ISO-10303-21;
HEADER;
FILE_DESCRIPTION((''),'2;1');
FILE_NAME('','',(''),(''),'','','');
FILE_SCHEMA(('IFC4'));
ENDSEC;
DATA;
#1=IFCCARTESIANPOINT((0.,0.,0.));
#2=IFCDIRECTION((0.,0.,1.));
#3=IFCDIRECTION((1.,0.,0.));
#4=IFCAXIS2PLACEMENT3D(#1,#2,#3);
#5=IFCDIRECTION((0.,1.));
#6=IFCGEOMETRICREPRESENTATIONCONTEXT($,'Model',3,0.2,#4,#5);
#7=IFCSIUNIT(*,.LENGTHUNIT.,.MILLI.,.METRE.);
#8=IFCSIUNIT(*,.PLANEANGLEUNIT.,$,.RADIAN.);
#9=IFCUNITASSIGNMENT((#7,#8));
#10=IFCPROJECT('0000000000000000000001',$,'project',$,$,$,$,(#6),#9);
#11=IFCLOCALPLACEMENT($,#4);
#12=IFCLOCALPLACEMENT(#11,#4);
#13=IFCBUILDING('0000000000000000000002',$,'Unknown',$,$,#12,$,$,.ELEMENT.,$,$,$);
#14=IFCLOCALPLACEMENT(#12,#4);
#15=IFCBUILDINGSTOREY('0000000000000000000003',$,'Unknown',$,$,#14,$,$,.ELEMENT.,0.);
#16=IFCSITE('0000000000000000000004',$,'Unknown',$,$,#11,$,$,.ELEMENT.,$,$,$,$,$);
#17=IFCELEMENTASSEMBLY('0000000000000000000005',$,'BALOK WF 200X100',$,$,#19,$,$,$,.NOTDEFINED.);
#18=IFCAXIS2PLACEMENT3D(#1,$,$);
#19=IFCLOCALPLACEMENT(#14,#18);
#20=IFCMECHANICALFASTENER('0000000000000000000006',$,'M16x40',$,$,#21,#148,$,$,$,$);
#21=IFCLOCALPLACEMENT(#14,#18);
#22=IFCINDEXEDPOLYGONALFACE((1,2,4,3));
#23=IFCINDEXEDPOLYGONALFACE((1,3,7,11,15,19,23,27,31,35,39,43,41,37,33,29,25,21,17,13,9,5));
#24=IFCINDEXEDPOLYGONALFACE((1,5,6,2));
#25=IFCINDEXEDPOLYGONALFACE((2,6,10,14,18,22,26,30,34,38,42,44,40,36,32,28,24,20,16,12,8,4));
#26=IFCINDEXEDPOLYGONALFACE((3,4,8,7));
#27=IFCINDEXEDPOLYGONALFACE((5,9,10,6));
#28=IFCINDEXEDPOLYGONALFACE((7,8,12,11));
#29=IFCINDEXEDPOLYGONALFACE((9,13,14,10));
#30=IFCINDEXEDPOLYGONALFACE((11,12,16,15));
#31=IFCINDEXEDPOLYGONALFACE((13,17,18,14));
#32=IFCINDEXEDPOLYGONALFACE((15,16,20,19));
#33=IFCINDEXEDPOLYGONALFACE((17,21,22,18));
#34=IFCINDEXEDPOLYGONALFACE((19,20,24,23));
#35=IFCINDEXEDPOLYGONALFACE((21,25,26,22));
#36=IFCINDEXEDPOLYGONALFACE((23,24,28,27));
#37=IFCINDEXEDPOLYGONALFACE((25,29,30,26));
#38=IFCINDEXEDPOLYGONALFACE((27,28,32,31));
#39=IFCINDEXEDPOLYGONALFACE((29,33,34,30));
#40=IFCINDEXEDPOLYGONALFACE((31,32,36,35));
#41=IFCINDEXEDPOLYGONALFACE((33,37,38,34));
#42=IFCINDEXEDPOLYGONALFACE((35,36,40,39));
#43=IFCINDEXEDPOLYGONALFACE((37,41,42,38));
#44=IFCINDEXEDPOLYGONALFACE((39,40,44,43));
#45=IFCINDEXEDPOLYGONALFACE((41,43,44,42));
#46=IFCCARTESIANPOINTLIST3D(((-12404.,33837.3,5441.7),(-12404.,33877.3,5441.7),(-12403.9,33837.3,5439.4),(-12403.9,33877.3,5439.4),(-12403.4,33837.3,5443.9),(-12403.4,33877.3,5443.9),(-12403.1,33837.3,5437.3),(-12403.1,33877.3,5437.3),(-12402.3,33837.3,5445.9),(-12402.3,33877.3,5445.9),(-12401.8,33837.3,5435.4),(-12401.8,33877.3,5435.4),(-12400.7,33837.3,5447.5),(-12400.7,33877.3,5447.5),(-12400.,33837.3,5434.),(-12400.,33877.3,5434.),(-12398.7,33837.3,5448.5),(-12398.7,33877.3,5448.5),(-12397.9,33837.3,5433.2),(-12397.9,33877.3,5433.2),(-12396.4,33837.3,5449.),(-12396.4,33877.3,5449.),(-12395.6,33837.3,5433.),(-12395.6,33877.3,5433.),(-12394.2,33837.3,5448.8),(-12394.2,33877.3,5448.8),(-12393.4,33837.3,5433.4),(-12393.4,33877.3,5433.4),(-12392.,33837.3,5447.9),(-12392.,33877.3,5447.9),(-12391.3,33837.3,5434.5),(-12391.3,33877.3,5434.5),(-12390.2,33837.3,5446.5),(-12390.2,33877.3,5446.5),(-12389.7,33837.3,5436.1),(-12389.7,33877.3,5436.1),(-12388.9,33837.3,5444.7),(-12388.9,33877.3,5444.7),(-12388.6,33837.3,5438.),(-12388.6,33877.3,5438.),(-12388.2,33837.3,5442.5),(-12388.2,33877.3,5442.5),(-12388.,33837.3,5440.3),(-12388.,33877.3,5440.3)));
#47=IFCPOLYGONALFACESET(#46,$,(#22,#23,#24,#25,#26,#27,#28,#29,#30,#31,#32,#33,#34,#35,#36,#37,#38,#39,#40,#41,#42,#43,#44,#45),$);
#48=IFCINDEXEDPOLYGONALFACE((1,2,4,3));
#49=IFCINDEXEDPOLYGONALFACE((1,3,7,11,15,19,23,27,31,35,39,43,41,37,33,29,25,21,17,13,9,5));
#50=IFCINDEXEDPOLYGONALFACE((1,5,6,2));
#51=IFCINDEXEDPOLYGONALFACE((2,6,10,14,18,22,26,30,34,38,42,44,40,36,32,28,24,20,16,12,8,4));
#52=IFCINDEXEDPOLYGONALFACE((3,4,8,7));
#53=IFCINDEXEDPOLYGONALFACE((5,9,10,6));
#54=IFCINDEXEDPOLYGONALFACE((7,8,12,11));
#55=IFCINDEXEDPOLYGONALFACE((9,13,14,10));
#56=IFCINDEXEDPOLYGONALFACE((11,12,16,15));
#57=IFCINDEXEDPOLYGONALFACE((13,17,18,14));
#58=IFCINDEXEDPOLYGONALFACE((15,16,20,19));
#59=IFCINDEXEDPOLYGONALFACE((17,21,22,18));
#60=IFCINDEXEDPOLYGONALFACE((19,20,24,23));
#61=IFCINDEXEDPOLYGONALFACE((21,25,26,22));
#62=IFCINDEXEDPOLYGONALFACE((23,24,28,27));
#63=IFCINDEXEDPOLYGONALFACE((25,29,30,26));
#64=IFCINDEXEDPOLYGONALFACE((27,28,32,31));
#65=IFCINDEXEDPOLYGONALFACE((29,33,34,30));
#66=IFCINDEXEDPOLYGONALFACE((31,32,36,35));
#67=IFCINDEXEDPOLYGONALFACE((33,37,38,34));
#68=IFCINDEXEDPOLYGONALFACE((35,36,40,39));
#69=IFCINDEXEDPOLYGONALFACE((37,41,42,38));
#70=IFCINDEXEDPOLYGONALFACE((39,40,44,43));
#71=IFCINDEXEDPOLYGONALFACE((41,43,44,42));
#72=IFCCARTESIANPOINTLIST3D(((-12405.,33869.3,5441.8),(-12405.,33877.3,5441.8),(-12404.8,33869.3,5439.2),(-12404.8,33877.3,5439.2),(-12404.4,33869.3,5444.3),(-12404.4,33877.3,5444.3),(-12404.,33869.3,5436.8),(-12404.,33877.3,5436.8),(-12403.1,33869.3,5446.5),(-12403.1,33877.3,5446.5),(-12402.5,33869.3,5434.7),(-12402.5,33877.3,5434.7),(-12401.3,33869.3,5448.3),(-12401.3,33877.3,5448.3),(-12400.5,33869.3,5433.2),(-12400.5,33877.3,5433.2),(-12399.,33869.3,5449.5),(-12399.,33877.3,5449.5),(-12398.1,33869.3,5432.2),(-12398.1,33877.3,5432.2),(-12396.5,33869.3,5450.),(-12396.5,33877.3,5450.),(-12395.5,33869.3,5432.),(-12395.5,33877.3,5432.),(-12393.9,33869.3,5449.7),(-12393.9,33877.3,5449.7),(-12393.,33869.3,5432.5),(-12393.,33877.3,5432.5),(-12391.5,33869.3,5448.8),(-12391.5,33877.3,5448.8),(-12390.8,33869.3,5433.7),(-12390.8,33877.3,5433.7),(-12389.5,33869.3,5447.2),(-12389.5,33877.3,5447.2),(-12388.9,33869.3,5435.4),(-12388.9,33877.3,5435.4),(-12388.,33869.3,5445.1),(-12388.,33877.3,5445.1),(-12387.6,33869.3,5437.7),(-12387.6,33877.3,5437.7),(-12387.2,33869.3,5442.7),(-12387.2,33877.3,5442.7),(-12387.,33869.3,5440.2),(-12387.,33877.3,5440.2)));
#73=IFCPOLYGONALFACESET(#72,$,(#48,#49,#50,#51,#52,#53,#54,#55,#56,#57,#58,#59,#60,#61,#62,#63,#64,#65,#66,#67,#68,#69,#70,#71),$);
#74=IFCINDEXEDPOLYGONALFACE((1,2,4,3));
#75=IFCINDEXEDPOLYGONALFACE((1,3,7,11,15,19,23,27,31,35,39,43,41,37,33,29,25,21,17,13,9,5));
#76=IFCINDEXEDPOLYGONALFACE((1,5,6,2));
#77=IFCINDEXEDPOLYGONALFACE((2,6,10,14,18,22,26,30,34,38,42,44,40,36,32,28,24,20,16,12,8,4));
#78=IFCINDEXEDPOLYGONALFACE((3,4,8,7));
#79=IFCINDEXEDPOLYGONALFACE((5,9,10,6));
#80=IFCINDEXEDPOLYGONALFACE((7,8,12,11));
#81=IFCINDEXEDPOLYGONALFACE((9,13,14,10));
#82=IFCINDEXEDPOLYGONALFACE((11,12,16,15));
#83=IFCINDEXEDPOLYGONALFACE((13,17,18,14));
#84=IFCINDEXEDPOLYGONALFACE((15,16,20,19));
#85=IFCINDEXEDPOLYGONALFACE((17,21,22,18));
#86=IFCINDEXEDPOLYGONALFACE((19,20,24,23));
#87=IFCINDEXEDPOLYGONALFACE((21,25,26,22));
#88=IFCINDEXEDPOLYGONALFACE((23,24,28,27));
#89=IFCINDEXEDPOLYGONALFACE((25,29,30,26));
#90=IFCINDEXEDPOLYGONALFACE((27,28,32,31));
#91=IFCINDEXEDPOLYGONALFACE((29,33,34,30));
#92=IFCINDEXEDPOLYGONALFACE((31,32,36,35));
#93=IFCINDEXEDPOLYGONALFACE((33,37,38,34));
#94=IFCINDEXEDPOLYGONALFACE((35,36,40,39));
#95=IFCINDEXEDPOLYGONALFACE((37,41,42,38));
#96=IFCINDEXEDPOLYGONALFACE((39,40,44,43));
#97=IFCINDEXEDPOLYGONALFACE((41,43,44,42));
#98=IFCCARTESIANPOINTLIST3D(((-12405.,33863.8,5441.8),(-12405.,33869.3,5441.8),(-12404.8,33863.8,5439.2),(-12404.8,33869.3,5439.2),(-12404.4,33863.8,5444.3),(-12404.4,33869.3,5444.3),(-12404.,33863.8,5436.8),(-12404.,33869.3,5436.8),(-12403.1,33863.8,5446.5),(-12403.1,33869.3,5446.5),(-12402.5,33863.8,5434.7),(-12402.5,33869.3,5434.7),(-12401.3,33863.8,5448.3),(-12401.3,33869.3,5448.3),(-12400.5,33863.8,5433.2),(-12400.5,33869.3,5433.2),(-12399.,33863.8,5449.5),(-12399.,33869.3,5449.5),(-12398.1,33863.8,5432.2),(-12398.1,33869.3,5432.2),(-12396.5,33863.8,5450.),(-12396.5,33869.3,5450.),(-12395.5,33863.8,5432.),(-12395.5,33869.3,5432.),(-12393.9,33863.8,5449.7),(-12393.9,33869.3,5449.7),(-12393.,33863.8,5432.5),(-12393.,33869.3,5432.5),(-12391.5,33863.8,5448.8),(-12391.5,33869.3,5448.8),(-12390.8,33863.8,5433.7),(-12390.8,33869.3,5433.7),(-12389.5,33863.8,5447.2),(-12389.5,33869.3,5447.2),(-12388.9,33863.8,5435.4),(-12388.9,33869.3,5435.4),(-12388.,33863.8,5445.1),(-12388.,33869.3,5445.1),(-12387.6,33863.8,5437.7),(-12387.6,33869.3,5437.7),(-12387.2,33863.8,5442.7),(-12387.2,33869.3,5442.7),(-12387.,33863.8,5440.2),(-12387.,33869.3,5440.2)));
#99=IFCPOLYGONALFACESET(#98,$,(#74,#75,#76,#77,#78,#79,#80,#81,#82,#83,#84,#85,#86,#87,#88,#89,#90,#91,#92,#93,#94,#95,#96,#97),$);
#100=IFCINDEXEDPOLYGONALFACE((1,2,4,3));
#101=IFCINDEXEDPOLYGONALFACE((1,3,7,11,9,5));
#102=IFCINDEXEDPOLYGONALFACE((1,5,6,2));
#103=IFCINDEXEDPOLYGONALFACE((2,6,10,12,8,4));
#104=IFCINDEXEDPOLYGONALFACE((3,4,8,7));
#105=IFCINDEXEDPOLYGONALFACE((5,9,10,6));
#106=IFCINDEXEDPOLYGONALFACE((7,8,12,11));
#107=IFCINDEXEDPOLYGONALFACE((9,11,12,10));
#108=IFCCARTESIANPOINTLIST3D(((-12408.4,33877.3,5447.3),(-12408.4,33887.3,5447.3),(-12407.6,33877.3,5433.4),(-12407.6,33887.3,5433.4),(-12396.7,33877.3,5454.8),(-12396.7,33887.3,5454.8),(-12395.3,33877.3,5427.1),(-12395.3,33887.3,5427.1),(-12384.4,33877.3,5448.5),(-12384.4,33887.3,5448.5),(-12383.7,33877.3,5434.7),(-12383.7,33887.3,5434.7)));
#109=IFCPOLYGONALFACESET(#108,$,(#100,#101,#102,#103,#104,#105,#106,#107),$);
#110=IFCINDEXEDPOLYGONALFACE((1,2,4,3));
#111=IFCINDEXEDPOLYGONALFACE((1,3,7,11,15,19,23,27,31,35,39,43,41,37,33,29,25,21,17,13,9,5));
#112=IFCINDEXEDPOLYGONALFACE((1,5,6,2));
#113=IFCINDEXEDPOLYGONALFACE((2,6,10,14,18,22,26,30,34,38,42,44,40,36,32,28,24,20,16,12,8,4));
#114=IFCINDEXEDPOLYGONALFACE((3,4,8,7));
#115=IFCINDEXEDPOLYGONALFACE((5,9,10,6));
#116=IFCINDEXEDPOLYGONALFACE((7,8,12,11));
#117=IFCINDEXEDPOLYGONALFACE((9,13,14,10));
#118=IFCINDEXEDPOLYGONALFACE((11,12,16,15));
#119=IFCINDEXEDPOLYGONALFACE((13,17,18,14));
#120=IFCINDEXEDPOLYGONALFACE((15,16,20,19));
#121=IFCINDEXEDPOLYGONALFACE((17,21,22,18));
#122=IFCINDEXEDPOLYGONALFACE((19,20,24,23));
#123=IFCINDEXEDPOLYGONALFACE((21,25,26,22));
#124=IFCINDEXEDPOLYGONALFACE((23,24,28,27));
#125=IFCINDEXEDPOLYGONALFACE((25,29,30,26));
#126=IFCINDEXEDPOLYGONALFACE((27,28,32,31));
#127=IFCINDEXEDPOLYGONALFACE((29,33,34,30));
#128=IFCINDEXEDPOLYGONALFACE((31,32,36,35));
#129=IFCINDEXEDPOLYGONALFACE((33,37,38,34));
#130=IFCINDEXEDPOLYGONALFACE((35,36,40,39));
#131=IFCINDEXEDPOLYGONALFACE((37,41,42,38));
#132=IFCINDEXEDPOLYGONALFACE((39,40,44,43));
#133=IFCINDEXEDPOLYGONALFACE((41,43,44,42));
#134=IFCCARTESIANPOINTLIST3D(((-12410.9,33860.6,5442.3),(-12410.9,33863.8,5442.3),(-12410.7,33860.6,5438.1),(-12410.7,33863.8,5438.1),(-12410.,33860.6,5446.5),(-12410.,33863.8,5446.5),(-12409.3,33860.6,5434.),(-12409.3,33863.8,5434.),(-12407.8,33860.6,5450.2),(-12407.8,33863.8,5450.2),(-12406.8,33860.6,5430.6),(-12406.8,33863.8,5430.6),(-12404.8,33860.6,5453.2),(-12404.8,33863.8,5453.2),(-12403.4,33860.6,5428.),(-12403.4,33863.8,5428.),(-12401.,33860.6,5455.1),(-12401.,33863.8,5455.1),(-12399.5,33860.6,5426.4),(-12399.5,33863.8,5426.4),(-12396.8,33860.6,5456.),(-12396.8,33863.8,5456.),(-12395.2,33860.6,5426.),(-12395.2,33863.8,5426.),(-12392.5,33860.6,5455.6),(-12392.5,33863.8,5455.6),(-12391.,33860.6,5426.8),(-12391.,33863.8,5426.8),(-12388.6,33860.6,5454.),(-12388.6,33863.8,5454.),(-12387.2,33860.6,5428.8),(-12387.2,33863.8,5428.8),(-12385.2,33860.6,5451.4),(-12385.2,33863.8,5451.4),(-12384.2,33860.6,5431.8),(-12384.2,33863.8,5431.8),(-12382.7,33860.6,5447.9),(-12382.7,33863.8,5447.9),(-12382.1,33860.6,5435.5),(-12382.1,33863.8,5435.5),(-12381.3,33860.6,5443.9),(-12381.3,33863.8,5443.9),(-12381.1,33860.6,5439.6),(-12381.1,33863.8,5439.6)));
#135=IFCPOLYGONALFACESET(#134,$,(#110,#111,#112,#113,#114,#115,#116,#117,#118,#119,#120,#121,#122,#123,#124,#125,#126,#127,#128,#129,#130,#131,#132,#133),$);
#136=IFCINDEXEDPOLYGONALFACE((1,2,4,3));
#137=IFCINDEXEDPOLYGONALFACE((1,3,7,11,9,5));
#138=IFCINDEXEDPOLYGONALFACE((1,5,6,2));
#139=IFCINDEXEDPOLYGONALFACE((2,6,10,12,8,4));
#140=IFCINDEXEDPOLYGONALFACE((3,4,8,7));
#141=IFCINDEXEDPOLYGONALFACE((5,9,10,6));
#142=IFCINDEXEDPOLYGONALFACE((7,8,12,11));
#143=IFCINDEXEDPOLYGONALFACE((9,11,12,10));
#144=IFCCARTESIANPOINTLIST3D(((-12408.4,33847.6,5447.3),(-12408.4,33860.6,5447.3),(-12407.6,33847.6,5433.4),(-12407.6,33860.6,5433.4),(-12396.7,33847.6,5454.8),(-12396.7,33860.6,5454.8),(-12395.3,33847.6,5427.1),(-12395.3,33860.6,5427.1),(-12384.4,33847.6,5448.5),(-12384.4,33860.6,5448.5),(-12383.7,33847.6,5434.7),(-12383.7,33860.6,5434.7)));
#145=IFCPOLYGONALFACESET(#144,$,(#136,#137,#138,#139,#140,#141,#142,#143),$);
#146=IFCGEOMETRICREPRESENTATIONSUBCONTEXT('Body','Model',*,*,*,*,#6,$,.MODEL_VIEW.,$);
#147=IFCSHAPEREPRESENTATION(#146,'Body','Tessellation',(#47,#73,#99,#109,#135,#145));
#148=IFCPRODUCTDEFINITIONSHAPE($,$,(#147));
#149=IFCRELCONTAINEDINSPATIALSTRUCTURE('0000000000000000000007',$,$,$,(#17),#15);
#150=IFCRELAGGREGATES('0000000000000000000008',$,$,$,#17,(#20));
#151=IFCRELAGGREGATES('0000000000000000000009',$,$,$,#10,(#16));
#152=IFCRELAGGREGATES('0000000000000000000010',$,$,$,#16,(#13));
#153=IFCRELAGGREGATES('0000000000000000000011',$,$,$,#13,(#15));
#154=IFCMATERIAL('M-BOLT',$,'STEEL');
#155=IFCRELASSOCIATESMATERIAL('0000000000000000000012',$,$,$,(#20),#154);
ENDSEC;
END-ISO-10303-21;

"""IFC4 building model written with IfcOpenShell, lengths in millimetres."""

from ifc_helpers import new_model, si_unit, direction, frame, origin_with_axes, place, context, subcontext, project, spatial, line, arc, indexed_curve, outline, extrude, source, transform, mapped, material, element, aggregate, save


model = new_model("IFC4")

# Units and contexts
model_context = context("Model", 3, precision=0.2, world=origin_with_axes(), true_north=direction((0.0, 1.0)))
body_context = subcontext(model_context, "Body", "Model", "MODEL_VIEW")
ifc_project = project(units=[si_unit("LENGTHUNIT", "METRE", prefix="MILLI"), si_unit("PLANEANGLEUNIT", "RADIAN")], contexts=[model_context])

# Site, building, storey
site_placement = place(None, origin_with_axes())
site = spatial("IfcSite", under=ifc_project, at=site_placement, Name="Unknown", CompositionType="ELEMENT")
building_placement = place(site_placement, origin_with_axes())
building = spatial("IfcBuilding", under=site, at=building_placement, Name="Unknown", CompositionType="ELEMENT")
storey_placement = place(building_placement, origin_with_axes())
storey = spatial("IfcBuildingStorey", under=building, at=storey_placement, Name="Unknown", CompositionType="ELEMENT", Elevation=0.0)

# Element assembly, mechanical fastener
assembly_1_placement = place(storey_placement, frame((-7044.1, 33866.5, 5721.5), z_axis=(0.0, 1.0, 0.0), x_axis=(-0.99863, 0.0, -0.052336)))
assembly_1 = element("IfcElementAssembly", 1, at=assembly_1_placement, inside=storey, Name="BALOK WF 200X100", PredefinedType="NOTDEFINED")
ifc_material_1 = material(Name="M-BOLT", Category="STEEL")
shared_shape_1 = source(origin_with_axes(), body_context, "Body", "SweptSolid", [
    extrude(outline(indexed_curve([(8.0, 0.0), (0.0, 8.0), (-8.0, 0.0), (0.0, -8.0)], segments=[arc(1, 2, 3), arc(3, 4, 1)])), frame((0.0, 0.0, 0.0), z_axis=(0.0, 0.0, -1.0), x_axis=(0.0, 1.0, 0.0)), (0.0, 0.0, 1.0), 40.0),
    extrude(outline(indexed_curve([(9.0, 0.0), (0.0, 9.0), (-9.0, 0.0), (0.0, -9.0)], segments=[arc(1, 2, 3), arc(3, 4, 1)])), frame((0.0, 0.0, 0.0), z_axis=(0.0, 0.0, -1.0), x_axis=(0.0, 1.0, 0.0)), (0.0, 0.0, 1.0), 8.0),
    extrude(outline(indexed_curve([(9.0, 0.0), (0.0, 9.0), (-9.0, 0.0), (0.0, -9.0)], segments=[arc(1, 2, 3), arc(3, 4, 1)])), frame((0.0, 0.0, -8.0), z_axis=(0.0, 0.0, -1.0), x_axis=(0.0, 1.0, 0.0)), (0.0, 0.0, 1.0), 5.5),
    extrude(outline(indexed_curve([(13.9, 0.0), (6.9, 12.0), (-6.9, 12.0), (-13.9, 0.0), (-6.9, -12.0), (6.9, -12.0)], segments=[line(1, 2, 3, 4, 5, 6, 1)])), frame((0.0, 0.0, 10.0), z_axis=(0.0, 0.0, -1.0), x_axis=(0.0, 1.0, 0.0)), (0.0, 0.0, 1.0), 10.0),
    extrude(outline(indexed_curve([(15.0, 0.0), (0.0, 15.0), (-15.0, 0.0), (0.0, -15.0)], segments=[arc(1, 2, 3), arc(3, 4, 1)])), frame((0.0, 0.0, -13.5), z_axis=(0.0, 0.0, -1.0), x_axis=(0.0, 1.0, 0.0)), (0.0, 0.0, 1.0), 3.2),
    extrude(outline(indexed_curve([(13.9, 0.0), (6.9, 12.0), (-6.9, 12.0), (-13.9, 0.0), (-6.9, -12.0), (6.9, -12.0)], segments=[line(1, 2, 3, 4, 5, 6, 1)])), frame((0.0, 0.0, -16.7), z_axis=(0.0, 0.0, -1.0), x_axis=(0.0, 1.0, 0.0)), (0.0, 0.0, 1.0), 13.0),
])
mechanical_fastener_1_placement = place(assembly_1_placement, frame((5359.2, 0.0, 10.7), z_axis=(-0.000004, 0.0, 1.0), x_axis=(-1.0, 0.0, -0.000004)))
mechanical_fastener_1 = element("IfcMechanicalFastener", 2, at=mechanical_fastener_1_placement, material=ifc_material_1, Name="M16x40", context=body_context, shape_type="MappedRepresentation", body=[
    mapped(shared_shape_1, transform((0.0, 0.0, 0.0))),
])
aggregate(assembly_1, [mechanical_fastener_1])

save(model, "model.ifc")
